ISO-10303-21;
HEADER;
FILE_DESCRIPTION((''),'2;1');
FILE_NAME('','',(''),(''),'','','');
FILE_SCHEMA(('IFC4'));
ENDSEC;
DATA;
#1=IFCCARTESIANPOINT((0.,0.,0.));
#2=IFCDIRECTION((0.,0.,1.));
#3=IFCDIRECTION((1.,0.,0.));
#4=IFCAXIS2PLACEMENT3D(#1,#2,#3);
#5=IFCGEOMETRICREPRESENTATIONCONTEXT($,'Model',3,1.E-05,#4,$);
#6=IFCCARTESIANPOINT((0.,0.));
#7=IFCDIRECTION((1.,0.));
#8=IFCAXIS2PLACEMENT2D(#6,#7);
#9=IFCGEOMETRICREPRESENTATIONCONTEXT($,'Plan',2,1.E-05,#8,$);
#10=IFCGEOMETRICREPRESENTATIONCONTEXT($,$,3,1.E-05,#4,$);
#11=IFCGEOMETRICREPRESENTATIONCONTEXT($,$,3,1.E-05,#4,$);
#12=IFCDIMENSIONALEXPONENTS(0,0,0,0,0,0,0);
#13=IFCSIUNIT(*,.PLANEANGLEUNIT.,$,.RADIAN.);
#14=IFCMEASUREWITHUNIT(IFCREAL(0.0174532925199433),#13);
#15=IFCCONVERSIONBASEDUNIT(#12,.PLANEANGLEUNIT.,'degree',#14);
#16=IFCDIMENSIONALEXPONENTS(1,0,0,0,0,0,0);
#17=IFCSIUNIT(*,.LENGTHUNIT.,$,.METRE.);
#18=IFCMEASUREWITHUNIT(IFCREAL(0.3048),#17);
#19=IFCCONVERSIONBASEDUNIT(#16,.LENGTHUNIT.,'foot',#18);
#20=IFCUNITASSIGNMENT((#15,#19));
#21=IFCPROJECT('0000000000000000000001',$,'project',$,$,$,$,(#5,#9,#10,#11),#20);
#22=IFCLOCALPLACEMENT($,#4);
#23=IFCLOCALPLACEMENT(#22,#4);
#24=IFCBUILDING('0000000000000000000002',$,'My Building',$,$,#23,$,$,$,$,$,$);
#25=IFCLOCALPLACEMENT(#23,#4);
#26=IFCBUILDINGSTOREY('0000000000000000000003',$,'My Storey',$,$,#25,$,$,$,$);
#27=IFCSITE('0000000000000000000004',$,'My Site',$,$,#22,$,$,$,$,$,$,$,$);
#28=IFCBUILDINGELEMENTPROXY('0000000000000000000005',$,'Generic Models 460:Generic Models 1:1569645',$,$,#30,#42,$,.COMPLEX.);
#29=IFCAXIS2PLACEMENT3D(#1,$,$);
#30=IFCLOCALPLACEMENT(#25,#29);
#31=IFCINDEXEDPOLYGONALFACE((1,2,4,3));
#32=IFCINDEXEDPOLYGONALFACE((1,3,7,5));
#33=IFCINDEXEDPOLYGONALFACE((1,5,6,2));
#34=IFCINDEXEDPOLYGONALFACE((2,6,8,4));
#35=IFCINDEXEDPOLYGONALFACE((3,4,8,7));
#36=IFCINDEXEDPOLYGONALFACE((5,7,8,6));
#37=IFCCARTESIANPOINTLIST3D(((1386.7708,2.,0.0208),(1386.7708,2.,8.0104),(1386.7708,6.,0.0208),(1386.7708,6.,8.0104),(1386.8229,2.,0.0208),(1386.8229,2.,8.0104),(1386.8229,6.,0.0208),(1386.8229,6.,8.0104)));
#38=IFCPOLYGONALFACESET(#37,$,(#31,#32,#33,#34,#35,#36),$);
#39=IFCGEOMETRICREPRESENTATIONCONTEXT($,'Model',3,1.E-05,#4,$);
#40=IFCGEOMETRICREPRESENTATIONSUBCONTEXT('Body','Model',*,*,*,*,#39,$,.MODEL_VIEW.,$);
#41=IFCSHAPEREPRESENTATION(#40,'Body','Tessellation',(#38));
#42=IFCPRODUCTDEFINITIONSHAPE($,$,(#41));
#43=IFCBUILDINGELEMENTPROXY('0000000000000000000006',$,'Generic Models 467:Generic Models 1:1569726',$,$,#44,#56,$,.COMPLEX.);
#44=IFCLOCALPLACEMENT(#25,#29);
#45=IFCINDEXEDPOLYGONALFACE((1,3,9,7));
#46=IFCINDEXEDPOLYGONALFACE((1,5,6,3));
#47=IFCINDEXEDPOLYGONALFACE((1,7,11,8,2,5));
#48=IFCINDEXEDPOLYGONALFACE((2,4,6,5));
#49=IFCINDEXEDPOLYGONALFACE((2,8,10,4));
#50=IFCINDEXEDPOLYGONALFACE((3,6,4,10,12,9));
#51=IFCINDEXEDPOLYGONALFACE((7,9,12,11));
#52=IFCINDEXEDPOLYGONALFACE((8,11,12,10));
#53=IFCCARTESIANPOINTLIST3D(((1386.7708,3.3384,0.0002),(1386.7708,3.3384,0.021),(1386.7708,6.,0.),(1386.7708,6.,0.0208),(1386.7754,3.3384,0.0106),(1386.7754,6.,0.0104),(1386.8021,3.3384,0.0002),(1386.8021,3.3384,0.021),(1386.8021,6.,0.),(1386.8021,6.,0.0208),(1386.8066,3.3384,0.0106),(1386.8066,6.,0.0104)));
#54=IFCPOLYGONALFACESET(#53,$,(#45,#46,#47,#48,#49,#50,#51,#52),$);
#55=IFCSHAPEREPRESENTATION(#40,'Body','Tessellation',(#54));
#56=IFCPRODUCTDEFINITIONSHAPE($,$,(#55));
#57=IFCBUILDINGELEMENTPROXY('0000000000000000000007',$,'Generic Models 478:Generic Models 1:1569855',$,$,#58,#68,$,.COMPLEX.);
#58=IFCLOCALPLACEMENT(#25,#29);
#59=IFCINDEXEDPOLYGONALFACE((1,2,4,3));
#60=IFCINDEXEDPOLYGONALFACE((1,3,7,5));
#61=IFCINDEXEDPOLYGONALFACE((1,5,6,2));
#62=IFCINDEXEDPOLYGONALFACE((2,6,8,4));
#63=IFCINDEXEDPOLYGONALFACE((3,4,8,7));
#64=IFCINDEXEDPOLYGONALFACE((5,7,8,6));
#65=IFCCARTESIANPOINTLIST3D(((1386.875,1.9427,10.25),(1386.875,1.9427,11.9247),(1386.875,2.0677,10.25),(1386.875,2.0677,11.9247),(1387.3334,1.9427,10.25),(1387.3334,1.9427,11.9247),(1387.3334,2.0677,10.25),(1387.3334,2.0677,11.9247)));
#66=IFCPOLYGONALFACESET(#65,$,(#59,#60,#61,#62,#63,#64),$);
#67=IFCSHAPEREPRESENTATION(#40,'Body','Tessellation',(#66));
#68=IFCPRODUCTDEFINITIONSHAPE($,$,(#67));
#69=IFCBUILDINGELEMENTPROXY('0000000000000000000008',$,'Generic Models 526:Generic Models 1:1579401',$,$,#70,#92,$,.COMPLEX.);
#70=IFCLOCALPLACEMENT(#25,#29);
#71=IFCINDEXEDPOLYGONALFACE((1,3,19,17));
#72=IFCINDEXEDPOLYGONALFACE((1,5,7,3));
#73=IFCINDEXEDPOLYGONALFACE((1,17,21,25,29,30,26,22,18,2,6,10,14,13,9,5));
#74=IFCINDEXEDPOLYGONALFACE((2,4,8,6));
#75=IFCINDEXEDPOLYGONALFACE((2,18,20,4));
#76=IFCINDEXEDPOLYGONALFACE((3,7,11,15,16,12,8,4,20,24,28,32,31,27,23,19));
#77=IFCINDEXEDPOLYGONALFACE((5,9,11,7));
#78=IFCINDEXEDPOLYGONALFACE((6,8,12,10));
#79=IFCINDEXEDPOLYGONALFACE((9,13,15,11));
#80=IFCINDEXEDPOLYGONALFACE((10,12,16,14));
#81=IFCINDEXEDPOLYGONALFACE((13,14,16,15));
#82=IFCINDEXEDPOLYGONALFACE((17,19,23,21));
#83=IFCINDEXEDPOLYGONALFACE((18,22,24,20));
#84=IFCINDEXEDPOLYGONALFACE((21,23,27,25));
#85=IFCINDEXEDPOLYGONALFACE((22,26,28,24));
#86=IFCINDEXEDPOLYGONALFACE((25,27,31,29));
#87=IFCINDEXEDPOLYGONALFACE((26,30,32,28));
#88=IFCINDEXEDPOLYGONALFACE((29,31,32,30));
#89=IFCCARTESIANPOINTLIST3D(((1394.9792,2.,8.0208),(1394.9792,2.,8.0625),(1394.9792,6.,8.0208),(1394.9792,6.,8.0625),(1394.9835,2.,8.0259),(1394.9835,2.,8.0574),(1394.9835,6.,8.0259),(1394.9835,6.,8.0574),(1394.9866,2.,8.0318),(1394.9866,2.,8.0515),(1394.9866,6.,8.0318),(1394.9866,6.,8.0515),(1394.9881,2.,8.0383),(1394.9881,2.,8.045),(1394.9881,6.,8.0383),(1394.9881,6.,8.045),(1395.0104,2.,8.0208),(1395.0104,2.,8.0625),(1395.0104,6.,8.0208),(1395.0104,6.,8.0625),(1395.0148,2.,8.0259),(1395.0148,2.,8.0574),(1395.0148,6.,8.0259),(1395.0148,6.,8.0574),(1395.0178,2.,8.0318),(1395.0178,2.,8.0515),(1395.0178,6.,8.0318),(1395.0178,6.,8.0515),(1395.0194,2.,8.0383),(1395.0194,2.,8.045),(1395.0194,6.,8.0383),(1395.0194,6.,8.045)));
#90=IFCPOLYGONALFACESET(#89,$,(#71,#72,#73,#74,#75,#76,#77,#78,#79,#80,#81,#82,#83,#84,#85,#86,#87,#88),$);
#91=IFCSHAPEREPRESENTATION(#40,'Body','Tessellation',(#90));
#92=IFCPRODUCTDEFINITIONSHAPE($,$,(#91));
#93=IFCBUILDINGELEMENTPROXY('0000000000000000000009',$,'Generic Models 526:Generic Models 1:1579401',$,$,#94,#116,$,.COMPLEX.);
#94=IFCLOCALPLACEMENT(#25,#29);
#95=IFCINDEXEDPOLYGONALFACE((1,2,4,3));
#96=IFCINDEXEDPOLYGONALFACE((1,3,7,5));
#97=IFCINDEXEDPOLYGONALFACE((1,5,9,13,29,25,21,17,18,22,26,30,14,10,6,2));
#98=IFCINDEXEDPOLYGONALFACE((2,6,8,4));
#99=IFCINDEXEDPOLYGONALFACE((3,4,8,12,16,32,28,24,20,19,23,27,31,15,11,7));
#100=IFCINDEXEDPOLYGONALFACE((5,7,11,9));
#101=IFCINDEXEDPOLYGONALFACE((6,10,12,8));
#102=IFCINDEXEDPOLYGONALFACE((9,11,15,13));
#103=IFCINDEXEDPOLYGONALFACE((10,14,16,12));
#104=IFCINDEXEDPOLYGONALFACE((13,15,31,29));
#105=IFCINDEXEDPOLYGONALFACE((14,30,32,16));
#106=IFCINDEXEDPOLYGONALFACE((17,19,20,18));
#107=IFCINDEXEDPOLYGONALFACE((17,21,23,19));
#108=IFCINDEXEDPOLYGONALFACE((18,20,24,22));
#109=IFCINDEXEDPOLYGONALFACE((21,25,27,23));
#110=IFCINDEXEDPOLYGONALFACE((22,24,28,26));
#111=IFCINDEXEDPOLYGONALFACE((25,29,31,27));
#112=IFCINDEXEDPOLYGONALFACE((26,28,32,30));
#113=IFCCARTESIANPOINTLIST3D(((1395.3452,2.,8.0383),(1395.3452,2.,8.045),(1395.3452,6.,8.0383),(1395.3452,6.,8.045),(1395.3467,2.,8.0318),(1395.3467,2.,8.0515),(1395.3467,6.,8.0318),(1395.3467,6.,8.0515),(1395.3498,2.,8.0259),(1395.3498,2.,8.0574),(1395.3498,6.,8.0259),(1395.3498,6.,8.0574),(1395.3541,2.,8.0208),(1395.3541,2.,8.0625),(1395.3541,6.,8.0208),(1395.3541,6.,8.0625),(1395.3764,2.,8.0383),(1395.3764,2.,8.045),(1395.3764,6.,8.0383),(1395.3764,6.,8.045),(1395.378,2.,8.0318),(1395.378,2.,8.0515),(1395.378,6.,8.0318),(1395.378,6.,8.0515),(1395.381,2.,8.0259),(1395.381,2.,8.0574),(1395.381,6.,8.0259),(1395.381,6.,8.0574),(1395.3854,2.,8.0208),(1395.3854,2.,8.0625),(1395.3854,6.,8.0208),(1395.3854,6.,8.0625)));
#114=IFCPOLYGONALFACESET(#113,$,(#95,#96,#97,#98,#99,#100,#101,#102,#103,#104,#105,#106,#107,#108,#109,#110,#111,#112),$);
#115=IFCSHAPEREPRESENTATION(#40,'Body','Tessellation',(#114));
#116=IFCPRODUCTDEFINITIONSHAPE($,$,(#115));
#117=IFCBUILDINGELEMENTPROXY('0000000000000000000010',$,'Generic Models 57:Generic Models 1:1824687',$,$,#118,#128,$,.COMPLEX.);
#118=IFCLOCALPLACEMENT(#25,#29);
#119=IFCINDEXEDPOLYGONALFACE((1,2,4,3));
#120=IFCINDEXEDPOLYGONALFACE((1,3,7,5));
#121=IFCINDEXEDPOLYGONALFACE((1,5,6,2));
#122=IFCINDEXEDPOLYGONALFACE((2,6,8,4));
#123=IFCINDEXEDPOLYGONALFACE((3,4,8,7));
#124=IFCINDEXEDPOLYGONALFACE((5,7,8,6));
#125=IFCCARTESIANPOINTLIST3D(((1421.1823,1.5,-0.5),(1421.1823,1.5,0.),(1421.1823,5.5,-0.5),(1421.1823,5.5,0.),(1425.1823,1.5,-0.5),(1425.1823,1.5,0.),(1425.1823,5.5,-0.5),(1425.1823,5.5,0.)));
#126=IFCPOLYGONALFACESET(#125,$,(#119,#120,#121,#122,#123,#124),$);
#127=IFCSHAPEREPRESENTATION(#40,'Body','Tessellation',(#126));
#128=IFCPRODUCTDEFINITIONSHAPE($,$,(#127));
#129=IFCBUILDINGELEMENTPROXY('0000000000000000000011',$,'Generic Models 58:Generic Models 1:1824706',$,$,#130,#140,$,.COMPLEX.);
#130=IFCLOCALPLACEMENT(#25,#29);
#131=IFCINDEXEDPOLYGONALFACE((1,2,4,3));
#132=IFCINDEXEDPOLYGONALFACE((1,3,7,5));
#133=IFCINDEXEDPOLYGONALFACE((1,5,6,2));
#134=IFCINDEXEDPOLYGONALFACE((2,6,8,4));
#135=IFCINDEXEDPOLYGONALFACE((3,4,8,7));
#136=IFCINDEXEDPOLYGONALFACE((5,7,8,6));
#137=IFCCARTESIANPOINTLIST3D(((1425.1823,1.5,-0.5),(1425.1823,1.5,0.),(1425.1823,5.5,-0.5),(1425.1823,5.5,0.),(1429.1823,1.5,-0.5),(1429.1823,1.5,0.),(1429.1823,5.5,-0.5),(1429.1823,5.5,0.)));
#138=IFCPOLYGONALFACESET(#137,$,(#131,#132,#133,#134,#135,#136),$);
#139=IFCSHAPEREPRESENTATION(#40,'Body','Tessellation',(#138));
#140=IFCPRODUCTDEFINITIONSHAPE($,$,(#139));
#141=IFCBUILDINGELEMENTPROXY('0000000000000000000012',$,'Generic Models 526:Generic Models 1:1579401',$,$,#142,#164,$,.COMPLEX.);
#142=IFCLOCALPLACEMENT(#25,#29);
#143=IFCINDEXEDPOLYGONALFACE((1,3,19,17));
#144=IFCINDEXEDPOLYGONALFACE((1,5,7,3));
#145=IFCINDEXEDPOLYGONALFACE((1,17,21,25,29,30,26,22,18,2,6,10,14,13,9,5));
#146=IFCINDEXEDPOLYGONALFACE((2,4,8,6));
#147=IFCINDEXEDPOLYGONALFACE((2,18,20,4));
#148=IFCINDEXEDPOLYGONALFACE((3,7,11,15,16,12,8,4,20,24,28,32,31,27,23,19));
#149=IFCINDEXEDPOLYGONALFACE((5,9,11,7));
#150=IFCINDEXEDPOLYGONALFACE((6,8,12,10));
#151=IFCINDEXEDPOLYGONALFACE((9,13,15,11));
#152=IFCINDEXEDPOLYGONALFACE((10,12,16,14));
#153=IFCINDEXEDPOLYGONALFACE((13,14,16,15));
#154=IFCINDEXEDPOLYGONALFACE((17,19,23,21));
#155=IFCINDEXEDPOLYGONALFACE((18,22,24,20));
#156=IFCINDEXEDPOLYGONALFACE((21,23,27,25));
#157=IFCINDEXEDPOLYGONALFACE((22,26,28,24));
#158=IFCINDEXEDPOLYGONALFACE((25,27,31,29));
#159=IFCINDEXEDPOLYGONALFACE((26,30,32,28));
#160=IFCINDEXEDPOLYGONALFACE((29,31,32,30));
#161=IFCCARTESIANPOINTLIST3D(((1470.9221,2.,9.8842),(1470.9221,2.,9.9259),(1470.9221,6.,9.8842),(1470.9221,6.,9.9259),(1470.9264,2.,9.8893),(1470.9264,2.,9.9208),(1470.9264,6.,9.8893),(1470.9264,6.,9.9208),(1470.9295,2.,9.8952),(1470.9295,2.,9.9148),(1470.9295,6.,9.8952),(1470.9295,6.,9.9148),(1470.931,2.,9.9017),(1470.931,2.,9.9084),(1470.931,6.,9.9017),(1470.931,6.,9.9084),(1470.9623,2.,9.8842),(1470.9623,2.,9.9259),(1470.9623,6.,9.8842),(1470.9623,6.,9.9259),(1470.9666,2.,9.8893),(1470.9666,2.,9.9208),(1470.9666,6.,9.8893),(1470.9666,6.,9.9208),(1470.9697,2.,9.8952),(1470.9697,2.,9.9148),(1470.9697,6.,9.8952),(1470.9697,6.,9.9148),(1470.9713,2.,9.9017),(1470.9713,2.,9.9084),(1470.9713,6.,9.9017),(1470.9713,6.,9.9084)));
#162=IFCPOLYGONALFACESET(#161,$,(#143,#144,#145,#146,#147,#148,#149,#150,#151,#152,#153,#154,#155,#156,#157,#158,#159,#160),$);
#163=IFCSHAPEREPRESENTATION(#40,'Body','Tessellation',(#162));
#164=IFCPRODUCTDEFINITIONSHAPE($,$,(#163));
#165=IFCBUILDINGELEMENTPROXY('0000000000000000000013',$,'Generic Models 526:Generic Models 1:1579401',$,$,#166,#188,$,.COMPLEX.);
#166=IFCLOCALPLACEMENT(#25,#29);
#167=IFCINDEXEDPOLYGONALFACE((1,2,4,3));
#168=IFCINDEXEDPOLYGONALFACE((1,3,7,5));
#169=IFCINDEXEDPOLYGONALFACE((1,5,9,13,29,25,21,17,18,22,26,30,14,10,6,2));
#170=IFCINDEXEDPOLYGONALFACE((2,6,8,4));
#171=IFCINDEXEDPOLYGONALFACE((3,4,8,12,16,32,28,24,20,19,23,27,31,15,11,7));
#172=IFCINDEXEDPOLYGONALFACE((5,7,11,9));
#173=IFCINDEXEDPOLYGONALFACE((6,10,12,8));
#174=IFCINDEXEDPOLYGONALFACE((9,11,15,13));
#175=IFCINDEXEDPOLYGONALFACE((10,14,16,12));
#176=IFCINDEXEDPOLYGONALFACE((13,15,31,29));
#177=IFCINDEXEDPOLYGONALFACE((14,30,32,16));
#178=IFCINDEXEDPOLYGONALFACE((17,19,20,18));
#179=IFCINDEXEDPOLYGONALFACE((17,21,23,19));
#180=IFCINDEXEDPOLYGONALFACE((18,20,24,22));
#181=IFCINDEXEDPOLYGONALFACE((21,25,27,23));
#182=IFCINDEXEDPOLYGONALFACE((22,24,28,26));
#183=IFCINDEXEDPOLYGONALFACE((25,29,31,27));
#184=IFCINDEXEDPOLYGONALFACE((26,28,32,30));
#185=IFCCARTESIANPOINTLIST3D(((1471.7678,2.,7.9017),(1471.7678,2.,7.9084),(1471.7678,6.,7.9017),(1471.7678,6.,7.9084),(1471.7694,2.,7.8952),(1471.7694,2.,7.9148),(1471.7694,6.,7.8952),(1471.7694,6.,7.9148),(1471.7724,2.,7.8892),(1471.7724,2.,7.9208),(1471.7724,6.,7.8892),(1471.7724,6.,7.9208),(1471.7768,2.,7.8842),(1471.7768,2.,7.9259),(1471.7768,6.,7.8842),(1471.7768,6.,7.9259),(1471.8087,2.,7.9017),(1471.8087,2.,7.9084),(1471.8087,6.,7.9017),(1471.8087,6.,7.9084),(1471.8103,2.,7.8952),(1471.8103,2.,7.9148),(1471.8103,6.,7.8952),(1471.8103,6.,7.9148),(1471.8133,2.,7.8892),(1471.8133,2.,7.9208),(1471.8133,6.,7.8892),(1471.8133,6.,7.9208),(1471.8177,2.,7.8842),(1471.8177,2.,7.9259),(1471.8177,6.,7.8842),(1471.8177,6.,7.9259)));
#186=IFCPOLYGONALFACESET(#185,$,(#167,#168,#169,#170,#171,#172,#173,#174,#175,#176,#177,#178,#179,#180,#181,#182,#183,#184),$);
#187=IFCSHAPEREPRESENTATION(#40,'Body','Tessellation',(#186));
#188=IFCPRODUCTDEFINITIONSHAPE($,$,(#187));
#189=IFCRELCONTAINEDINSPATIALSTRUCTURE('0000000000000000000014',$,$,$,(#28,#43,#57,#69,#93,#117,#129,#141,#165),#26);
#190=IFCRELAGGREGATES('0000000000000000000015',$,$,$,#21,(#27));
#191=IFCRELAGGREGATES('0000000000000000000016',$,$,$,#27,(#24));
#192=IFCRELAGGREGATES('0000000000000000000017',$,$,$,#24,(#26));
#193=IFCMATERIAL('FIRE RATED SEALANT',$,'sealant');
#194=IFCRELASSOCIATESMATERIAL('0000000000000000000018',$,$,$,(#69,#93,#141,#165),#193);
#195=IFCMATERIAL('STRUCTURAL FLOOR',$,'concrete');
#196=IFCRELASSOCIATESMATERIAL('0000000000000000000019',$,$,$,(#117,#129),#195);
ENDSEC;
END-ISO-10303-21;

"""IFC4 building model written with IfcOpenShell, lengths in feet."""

from ifc_helpers import new_model, entity, si_unit, converted_unit, frame, origin_with_axes, origin_2d_with_axis, place, context, subcontext, project, spatial, polyline, line, indexed_curve, outline, extrude, material, element, save


model = new_model("IFC4")

# Units and contexts
model_context_1 = context("Model", 3, precision=1e-05, world=origin_with_axes())
plan_context = context("Plan", 2, precision=1e-05, world=origin_2d_with_axis())
model_context_2 = context("Model", 3, precision=1e-05, world=origin_with_axes())
context_of_model_1 = context(None, 3, precision=1e-05, world=origin_with_axes())
context_of_model_2 = context(None, 3, precision=1e-05, world=origin_with_axes())
body_context_1 = subcontext(model_context_2, "Body", "Model", "MODEL_VIEW")
ifc_project = project(units=[converted_unit("PLANEANGLEUNIT", "degree", entity("IfcReal", 0.0174532925199433), si_unit("PLANEANGLEUNIT", "RADIAN"), dimensions=[0, 0, 0, 0, 0, 0, 0]), converted_unit("LENGTHUNIT", "foot", entity("IfcReal", 0.3048), si_unit("LENGTHUNIT", "METRE"), dimensions=[1, 0, 0, 0, 0, 0, 0])], contexts=[model_context_1, plan_context, context_of_model_1, context_of_model_2])

# Site, building, storey
site_placement = place(None, origin_with_axes())
site = spatial("IfcSite", under=ifc_project, at=site_placement, Name="My Site")
building_placement = place(site_placement, origin_with_axes())
building = spatial("IfcBuilding", under=site, at=building_placement, Name="My Building")
storey_placement = place(building_placement, origin_with_axes())
storey = spatial("IfcBuildingStorey", under=building, at=storey_placement, Name="My Storey")

# Building element proxies
ifc_material_1 = material(Name="STRUCTURAL FLOOR", Category="concrete")
proxy_1_placement = place(storey_placement, frame((1386.7708, 6.0, 0.0208), z_axis=(0.0, -1.0, 0.0), x_axis=(0.0, 0.0, 1.0)))
element("IfcBuildingElementProxy", 1, at=proxy_1_placement, inside=storey, Name="Generic Models 460:Generic Models 1:1569645", PredefinedType="COMPLEX", context=body_context_1, shape_type="SweptSolid", body=[
    extrude(outline(polyline([(-3.9948, -0.026), (3.9948, -0.026), (3.9948, 0.026), (-3.9948, 0.026), (-3.9948, -0.026)])), frame((3.9948, -0.026, 0.0), z_axis=(0.0, 0.0, -1.0), x_axis=(1.0, 0.0, 0.0)), (0.0, 0.0, -1.0), 4.0),
])
proxy_2_placement = place(storey_placement, frame((1386.7708, 6.0, 0.0), z_axis=(0.0, -1.0, 0.0), x_axis=(0.0, 0.0, 1.0)))
element("IfcBuildingElementProxy", 2, at=proxy_2_placement, inside=storey, Name="Generic Models 467:Generic Models 1:1569726", PredefinedType="COMPLEX", context=body_context_1, shape_type="SweptSolid", body=[
    extrude(outline(polyline([(0.0201, 0.0), (-0.0066, 0.0162), (-0.016, 0.0097), (-0.0175, -0.0016), (0.0093, -0.0178), (0.0107, -0.0065), (0.0201, 0.0)])), frame((0.0104, -0.0172, 0.0), z_axis=(0.0, 0.0, -1.0), x_axis=(0.51911, 0.854708, 0.0)), (0.000035, 0.000056, -1.0), 2.6616),
])
proxy_3_placement = place(storey_placement, frame((1386.875, 5.9427, 10.25), z_axis=(0.0, -1.0, 0.0), x_axis=(1.0, 0.0, 0.0)))
element("IfcBuildingElementProxy", 3, at=proxy_3_placement, inside=storey, Name="Generic Models 478:Generic Models 1:1569855", PredefinedType="COMPLEX", context=body_context_1, shape_type="SweptSolid", body=[
    extrude(outline(polyline([(-0.8373, -0.2292), (0.8373, -0.2292), (0.8373, 0.2292), (-0.8373, 0.2292), (-0.8373, -0.2292)])), frame((0.2292, 0.8373, 3.875), z_axis=(0.0, 0.0, -1.0), x_axis=(0.0, 1.0, 0.0)), (0.0, 0.0, -1.0), 0.125),
])
ifc_material_2 = material(Name="FIRE RATED SEALANT", Category="sealant")
for number, where, z_axis, x_axis, name in (
    (4, (1394.9791, 6.0, 8.0208), (0.0, -1.0, 0.0), (0.0, 0.0, 1.0), "Generic Models 526:Generic Models 1:1579401"),
    (5, (1395.3854, 6.0, 8.0625), (0.0, -1.0, 0.0), (0.0, 0.0, -1.0), "Generic Models 526:Generic Models 1:1579401"),
):
    element("IfcBuildingElementProxy", number, at=place(storey_placement, frame(where, z_axis=z_axis, x_axis=x_axis)), inside=storey, material=ifc_material_2, Name=name, PredefinedType="COMPLEX", context=body_context_1, shape_type="SweptSolid", body=[
        extrude(outline(polyline([(0.0216, 0.0), (0.0223, 0.0066), (0.001, 0.0294), (0.0002, 0.0228), (-0.002, 0.0165), (-0.0057, 0.0109), (-0.0105, 0.0064), (-0.0163, 0.0031), (-0.0228, 0.0012), (-0.0294, 0.0009), (-0.008, -0.0219), (-0.0014, -0.0216), (0.005, -0.0197), (0.0108, -0.0164), (0.0157, -0.0119), (0.0194, -0.0063), (0.0216, 0.0)])), frame((0.0208, -0.0208, 0.0), z_axis=(0.0, 0.0, -1.0), x_axis=(-0.729168, -0.684334, 0.0)), (0.0, 0.0, -1.0), 4.0),
    ])
for number, where, z_axis, x_axis, name in (
    (6, (1421.1823, 5.5, -0.5), (0.0, -1.0, 0.0), (0.0, 0.0, 1.0), "Generic Models 57:Generic Models 1:1824687"),
    (7, (1425.1823, 5.5, -0.5), (0.0, -1.0, 0.0), (0.0, 0.0, 1.0), "Generic Models 58:Generic Models 1:1824706"),
):
    element("IfcBuildingElementProxy", number, at=place(storey_placement, frame(where, z_axis=z_axis, x_axis=x_axis)), inside=storey, material=ifc_material_1, Name=name, PredefinedType="COMPLEX", context=body_context_1, shape_type="SweptSolid", body=[
        extrude(outline(polyline([(-0.25, -2.0), (0.25, -2.0), (0.25, 2.0), (-0.25, 2.0), (-0.25, -2.0)])), frame((0.25, -2.0, 0.0), z_axis=(0.0, 0.0, -1.0), x_axis=(1.0, 0.0, 0.0)), (0.0, 0.0, -1.0), 4.0),
    ])
proxy_4_placement = place(storey_placement, frame((1470.922, 6.0, 9.8842), z_axis=(0.0, -1.0, 0.0), x_axis=(0.0, 0.0, 1.0)))
element("IfcBuildingElementProxy", 8, at=proxy_4_placement, inside=storey, material=ifc_material_2, Name="Generic Models 526:Generic Models 1:1579401", PredefinedType="COMPLEX", context=body_context_1, shape_type="SweptSolid", body=[
    extrude(outline(indexed_curve([(0.0285, 0.0001), (0.0278, -0.0065), (0.0255, -0.0128), (0.0219, -0.0184), (0.017, -0.023), (0.0112, -0.0263), (0.0048, -0.0281), (-0.0019, -0.0284), (-0.0294, 0.0009), (-0.0228, 0.0012), (-0.0163, 0.0031), (-0.0105, 0.0064), (-0.0057, 0.0109), (-0.002, 0.0165), (0.0002, 0.0228), (0.001, 0.0294)], segments=[line(12, 11), line(11, 10), line(10, 9), line(9, 8), line(8, 7), line(7, 6), line(6, 5), line(5, 4), line(4, 3), line(3, 2), line(2, 1), line(1, 16), line(16, 15), line(15, 14), line(14, 13), line(13, 12)], self_intersect=False)), frame((0.0208, -0.0208, 0.0), z_axis=(0.0, 0.0, -1.0), x_axis=(-0.729168, -0.684334, 0.0)), (0.0, 0.0, -1.0), 4.0),
])
proxy_5_placement = place(storey_placement, frame((1471.8177, 6.0, 7.9259), z_axis=(0.0, -1.0, 0.0), x_axis=(0.0, 0.0, -1.0)))
element("IfcBuildingElementProxy", 9, at=proxy_5_placement, inside=storey, material=ifc_material_2, Name="Generic Models 526:Generic Models 1:1579401", PredefinedType="COMPLEX", context=body_context_1, shape_type="SweptSolid", body=[
    extrude(outline(indexed_curve([(0.029, -0.0004), (0.0282, -0.007), (0.026, -0.0133), (0.0223, -0.0189), (0.0175, -0.0235), (0.0117, -0.0268), (0.0052, -0.0286), (-0.0014, -0.0289), (-0.0294, 0.0009), (-0.0228, 0.0012), (-0.0163, 0.0031), (-0.0105, 0.0064), (-0.0057, 0.0109), (-0.002, 0.0165), (0.0002, 0.0228), (0.001, 0.0294)], segments=[line(2, 1), line(1, 16), line(16, 15), line(15, 14), line(14, 13), line(13, 12), line(12, 11), line(11, 10), line(10, 9), line(9, 8), line(8, 7), line(7, 6), line(6, 5), line(5, 4), line(4, 3), line(3, 2)], self_intersect=False)), frame((0.0208, -0.0208, 0.0), z_axis=(0.0, 0.0, -1.0), x_axis=(-0.729168, -0.684334, 0.0)), (0.0, 0.0, -1.0), 4.0),
])

save(model, "model.ifc")
